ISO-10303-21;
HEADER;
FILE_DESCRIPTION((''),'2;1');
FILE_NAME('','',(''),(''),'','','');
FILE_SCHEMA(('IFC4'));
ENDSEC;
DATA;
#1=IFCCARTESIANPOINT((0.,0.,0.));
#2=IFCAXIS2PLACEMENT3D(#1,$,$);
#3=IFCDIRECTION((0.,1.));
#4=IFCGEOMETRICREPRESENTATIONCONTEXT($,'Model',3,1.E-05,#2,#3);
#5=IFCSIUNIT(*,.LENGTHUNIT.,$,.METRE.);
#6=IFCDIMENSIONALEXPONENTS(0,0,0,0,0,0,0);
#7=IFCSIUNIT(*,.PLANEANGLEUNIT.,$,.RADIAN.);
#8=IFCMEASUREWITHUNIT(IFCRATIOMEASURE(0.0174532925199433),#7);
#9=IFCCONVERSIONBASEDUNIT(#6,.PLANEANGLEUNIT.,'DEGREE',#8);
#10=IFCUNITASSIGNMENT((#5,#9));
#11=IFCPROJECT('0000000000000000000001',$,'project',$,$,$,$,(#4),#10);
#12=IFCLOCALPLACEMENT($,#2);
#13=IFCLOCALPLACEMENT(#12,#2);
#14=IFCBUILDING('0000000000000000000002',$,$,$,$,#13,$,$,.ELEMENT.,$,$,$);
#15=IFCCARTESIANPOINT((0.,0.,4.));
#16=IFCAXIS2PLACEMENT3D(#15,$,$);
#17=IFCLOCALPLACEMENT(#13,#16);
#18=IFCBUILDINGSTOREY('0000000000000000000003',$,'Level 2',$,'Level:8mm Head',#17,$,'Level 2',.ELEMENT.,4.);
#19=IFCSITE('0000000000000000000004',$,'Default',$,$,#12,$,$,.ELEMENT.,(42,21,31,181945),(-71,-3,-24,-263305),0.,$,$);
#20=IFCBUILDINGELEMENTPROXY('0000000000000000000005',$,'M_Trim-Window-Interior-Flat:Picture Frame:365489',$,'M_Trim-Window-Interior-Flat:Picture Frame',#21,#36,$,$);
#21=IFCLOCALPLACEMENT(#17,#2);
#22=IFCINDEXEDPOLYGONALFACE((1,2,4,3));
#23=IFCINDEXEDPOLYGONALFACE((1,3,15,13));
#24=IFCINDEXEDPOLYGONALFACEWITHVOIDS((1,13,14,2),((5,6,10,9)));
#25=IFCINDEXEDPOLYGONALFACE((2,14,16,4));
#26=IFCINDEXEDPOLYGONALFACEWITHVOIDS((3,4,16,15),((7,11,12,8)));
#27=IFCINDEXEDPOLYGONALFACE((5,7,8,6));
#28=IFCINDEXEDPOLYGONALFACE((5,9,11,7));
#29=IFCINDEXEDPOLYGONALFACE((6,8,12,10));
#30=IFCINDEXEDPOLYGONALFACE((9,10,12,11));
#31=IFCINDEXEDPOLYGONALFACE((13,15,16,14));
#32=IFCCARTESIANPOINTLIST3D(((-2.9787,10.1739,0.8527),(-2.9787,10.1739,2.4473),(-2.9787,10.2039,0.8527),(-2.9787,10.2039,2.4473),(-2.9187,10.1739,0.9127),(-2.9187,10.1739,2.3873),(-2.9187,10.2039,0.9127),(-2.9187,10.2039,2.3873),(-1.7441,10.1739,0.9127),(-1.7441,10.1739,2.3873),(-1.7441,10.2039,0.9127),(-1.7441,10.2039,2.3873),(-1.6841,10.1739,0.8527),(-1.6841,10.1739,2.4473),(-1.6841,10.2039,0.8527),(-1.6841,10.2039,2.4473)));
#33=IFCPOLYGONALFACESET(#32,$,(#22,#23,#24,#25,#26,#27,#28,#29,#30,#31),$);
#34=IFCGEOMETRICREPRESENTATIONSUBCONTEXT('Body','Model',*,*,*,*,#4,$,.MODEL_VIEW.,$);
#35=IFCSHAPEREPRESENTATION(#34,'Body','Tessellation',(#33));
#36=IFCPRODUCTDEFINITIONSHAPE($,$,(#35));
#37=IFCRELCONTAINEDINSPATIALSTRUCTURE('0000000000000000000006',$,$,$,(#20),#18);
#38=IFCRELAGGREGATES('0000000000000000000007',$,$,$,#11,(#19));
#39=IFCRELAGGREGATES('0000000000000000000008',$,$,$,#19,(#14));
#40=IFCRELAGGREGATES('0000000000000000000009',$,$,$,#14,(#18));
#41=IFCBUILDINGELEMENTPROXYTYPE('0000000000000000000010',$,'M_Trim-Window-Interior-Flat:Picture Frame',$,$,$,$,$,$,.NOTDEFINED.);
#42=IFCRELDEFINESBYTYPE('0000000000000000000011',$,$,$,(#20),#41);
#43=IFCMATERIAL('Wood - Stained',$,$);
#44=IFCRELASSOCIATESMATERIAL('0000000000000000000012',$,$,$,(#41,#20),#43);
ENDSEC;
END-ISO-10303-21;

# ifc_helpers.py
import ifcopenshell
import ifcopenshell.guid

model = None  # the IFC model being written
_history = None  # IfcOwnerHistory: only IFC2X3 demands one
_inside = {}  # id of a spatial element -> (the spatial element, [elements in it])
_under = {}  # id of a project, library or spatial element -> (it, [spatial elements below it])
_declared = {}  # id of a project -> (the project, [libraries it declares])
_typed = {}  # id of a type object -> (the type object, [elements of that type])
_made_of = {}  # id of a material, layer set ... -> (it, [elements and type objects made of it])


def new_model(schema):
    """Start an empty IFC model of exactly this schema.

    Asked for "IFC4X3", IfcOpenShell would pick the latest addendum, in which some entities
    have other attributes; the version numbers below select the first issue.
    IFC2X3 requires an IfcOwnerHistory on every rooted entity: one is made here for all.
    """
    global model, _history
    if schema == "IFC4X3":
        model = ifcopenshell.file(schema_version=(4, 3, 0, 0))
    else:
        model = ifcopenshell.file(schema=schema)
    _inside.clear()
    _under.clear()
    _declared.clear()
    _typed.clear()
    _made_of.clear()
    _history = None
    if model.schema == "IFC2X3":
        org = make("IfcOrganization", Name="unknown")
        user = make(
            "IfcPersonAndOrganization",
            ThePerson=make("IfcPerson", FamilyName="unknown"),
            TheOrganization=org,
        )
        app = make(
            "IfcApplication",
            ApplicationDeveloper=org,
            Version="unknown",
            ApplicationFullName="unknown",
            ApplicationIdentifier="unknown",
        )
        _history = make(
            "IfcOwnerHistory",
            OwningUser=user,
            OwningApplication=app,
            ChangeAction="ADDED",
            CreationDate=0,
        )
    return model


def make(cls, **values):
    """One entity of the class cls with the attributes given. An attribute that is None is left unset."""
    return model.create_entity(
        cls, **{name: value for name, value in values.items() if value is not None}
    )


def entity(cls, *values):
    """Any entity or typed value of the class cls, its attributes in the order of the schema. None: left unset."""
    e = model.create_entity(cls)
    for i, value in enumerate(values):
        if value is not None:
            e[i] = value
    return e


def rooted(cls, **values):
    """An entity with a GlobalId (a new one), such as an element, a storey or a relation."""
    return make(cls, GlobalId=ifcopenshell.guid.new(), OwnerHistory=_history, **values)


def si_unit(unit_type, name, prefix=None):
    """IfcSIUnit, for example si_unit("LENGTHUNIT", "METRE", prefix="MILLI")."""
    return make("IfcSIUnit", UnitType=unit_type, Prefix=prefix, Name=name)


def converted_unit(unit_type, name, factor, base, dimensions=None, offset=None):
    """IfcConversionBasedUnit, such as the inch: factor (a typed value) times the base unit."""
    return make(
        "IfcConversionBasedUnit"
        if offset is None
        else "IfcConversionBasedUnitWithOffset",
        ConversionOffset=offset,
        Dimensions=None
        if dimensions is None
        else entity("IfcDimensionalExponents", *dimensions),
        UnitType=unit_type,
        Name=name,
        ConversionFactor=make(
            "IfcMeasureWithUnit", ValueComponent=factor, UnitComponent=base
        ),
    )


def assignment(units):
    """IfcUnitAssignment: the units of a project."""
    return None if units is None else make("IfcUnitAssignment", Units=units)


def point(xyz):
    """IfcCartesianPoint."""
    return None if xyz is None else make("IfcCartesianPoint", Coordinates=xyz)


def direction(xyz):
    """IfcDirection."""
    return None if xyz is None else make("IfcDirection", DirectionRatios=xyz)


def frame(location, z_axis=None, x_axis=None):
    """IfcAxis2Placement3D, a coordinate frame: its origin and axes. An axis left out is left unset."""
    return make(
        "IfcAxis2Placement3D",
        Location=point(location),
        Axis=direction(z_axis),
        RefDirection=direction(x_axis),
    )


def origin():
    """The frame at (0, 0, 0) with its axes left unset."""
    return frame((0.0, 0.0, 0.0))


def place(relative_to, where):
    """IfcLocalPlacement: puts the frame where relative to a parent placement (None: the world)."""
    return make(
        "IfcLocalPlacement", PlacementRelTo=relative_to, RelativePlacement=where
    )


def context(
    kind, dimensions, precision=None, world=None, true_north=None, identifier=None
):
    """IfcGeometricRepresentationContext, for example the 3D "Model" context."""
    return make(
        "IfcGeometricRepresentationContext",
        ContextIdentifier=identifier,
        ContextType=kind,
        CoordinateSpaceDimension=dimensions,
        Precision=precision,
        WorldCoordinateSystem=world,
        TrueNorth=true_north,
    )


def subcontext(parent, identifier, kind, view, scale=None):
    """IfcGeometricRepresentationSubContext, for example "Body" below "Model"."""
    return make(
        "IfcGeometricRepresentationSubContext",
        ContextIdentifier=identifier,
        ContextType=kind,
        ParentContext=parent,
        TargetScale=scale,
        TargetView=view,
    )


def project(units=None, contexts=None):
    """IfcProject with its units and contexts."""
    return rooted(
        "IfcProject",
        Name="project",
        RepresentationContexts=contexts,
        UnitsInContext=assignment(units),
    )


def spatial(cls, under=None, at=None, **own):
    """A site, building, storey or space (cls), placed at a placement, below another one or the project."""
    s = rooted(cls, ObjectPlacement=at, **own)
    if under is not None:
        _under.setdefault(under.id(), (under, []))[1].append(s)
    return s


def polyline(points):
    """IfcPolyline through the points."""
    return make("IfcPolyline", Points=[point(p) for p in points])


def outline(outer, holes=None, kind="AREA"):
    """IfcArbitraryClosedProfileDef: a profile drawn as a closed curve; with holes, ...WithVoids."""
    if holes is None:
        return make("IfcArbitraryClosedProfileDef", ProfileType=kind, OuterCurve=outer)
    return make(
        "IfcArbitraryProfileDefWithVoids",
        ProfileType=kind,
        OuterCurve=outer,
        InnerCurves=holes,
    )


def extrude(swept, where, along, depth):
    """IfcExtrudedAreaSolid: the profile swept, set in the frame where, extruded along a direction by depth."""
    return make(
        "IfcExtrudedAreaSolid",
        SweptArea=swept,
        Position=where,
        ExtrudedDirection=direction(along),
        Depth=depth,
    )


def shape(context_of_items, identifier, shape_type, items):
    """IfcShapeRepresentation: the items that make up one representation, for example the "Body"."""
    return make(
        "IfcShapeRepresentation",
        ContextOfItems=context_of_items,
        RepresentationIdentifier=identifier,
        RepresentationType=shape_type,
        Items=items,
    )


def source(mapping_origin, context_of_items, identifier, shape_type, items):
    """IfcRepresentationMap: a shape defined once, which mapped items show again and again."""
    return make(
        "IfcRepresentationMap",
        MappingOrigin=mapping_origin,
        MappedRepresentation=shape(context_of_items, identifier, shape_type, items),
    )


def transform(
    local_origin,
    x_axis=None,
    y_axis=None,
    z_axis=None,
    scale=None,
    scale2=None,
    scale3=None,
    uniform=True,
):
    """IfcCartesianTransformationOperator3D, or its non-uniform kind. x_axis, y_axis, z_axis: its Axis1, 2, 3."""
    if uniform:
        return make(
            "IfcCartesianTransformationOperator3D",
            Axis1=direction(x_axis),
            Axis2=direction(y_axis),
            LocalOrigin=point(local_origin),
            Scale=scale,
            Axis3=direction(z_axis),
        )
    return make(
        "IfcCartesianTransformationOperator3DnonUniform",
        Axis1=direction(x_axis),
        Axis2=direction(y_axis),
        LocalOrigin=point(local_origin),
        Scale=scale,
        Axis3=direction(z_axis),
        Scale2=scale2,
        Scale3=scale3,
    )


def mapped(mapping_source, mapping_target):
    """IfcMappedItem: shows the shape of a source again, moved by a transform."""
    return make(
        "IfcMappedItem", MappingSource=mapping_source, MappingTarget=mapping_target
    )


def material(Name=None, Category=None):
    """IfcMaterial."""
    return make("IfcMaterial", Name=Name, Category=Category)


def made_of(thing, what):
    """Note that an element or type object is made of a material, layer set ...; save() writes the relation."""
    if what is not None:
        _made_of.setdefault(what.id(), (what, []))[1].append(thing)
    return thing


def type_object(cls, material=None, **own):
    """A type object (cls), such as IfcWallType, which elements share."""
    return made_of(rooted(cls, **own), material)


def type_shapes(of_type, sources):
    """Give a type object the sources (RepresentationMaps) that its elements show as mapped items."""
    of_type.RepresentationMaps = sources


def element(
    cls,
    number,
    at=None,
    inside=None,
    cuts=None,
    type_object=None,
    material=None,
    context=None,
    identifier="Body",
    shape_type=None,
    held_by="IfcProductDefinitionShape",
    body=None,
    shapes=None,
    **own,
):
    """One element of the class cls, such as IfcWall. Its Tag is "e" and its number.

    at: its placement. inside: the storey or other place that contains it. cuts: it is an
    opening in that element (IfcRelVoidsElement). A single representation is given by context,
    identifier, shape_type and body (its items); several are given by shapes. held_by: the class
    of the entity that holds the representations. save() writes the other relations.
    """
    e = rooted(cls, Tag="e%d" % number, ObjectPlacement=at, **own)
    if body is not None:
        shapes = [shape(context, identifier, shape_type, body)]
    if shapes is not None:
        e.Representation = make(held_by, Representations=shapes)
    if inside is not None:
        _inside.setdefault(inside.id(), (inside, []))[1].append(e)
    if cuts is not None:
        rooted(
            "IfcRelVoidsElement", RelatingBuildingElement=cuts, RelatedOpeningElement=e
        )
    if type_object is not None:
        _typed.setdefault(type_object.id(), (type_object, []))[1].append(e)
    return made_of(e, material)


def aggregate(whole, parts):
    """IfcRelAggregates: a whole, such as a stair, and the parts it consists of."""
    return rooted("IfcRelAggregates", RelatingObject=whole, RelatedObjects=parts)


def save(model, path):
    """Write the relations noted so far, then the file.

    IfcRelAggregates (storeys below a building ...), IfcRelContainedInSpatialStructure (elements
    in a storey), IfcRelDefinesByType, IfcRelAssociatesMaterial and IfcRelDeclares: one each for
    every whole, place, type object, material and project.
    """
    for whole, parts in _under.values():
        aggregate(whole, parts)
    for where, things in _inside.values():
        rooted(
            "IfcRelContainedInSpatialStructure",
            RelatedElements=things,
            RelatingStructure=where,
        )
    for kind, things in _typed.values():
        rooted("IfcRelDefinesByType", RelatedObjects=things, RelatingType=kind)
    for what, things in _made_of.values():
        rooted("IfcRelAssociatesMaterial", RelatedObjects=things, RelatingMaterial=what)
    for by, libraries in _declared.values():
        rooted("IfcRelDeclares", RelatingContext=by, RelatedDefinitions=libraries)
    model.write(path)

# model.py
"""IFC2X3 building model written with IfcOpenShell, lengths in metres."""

from ifc_helpers import new_model, entity, si_unit, converted_unit, direction, frame, origin, place, context, subcontext, project, spatial, polyline, outline, extrude, source, transform, mapped, material, type_object, type_shapes, element, save


model = new_model("IFC2X3")

# Units and contexts
model_context = context("Model", 3, precision=1e-05, world=origin(), true_north=direction((0.0, 1.0)))
body_context = subcontext(model_context, "Body", "Model", "MODEL_VIEW")
ifc_project = project(units=[si_unit("LENGTHUNIT", "METRE"), converted_unit("PLANEANGLEUNIT", "DEGREE", entity("IfcRatioMeasure", 0.0174532925199433), si_unit("PLANEANGLEUNIT", "RADIAN"), dimensions=[0, 0, 0, 0, 0, 0, 0])], contexts=[model_context])

# Site, building, storey
site_placement = place(None, origin())
site = spatial("IfcSite", under=ifc_project, at=site_placement, Name="Default", CompositionType="ELEMENT", RefLatitude=(42, 21, 31, 181945), RefLongitude=(-71, -3, -24, -263305), RefElevation=0.0)
building_placement = place(site_placement, origin())
building = spatial("IfcBuilding", under=site, at=building_placement, CompositionType="ELEMENT")
storey_placement = place(building_placement, frame((0.0, 0.0, 4.0)))
storey = spatial("IfcBuildingStorey", under=building, at=storey_placement, Name="Level 2", ObjectType="Level:8mm Head", LongName="Level 2", CompositionType="ELEMENT", Elevation=4.0)

# Shared definitions
ifc_material_1 = material(Name="Wood - Stained")

# Shared definitions
building_element_proxy_type_1 = type_object("IfcBuildingElementProxyType", Name="M_Trim-Window-Interior-Flat:Picture Frame", PredefinedType="NOTDEFINED", material=ifc_material_1)
shared_shape_1 = source(origin(), body_context, "Body", "SweptSolid", [
    extrude(outline(polyline([(-0.6473, -0.7973), (0.6473, -0.7973), (0.6473, 0.7973), (-0.6473, 0.7973), (-0.6473, -0.7973)]), holes=[polyline([(-0.5873, -0.7373), (-0.5873, 0.7373), (0.5873, 0.7373), (0.5873, -0.7373), (-0.5873, -0.7373)])]), frame((0.0, -0.75, 0.0), z_axis=(0.0, 0.0, 1.0), x_axis=(-1.0, 0.0, 0.0)), (0.0, 0.0, 1.0), 0.03),
])
type_shapes(building_element_proxy_type_1, [shared_shape_1])

# Building element proxy
proxy_1_placement = place(storey_placement, frame((-2.3314, 10.1739, 2.4), z_axis=(0.0, 1.0, 0.0), x_axis=(-1.0, 0.0, 0.0)))
element("IfcBuildingElementProxy", 1, at=proxy_1_placement, inside=storey, type_object=building_element_proxy_type_1, material=ifc_material_1, Name="M_Trim-Window-Interior-Flat:Picture Frame:365489", ObjectType="M_Trim-Window-Interior-Flat:Picture Frame", context=body_context, shape_type="MappedRepresentation", body=[
    mapped(shared_shape_1, transform((0.0, 0.0, 0.0), scale=1.0)),
])

save(model, "model.ifc")
